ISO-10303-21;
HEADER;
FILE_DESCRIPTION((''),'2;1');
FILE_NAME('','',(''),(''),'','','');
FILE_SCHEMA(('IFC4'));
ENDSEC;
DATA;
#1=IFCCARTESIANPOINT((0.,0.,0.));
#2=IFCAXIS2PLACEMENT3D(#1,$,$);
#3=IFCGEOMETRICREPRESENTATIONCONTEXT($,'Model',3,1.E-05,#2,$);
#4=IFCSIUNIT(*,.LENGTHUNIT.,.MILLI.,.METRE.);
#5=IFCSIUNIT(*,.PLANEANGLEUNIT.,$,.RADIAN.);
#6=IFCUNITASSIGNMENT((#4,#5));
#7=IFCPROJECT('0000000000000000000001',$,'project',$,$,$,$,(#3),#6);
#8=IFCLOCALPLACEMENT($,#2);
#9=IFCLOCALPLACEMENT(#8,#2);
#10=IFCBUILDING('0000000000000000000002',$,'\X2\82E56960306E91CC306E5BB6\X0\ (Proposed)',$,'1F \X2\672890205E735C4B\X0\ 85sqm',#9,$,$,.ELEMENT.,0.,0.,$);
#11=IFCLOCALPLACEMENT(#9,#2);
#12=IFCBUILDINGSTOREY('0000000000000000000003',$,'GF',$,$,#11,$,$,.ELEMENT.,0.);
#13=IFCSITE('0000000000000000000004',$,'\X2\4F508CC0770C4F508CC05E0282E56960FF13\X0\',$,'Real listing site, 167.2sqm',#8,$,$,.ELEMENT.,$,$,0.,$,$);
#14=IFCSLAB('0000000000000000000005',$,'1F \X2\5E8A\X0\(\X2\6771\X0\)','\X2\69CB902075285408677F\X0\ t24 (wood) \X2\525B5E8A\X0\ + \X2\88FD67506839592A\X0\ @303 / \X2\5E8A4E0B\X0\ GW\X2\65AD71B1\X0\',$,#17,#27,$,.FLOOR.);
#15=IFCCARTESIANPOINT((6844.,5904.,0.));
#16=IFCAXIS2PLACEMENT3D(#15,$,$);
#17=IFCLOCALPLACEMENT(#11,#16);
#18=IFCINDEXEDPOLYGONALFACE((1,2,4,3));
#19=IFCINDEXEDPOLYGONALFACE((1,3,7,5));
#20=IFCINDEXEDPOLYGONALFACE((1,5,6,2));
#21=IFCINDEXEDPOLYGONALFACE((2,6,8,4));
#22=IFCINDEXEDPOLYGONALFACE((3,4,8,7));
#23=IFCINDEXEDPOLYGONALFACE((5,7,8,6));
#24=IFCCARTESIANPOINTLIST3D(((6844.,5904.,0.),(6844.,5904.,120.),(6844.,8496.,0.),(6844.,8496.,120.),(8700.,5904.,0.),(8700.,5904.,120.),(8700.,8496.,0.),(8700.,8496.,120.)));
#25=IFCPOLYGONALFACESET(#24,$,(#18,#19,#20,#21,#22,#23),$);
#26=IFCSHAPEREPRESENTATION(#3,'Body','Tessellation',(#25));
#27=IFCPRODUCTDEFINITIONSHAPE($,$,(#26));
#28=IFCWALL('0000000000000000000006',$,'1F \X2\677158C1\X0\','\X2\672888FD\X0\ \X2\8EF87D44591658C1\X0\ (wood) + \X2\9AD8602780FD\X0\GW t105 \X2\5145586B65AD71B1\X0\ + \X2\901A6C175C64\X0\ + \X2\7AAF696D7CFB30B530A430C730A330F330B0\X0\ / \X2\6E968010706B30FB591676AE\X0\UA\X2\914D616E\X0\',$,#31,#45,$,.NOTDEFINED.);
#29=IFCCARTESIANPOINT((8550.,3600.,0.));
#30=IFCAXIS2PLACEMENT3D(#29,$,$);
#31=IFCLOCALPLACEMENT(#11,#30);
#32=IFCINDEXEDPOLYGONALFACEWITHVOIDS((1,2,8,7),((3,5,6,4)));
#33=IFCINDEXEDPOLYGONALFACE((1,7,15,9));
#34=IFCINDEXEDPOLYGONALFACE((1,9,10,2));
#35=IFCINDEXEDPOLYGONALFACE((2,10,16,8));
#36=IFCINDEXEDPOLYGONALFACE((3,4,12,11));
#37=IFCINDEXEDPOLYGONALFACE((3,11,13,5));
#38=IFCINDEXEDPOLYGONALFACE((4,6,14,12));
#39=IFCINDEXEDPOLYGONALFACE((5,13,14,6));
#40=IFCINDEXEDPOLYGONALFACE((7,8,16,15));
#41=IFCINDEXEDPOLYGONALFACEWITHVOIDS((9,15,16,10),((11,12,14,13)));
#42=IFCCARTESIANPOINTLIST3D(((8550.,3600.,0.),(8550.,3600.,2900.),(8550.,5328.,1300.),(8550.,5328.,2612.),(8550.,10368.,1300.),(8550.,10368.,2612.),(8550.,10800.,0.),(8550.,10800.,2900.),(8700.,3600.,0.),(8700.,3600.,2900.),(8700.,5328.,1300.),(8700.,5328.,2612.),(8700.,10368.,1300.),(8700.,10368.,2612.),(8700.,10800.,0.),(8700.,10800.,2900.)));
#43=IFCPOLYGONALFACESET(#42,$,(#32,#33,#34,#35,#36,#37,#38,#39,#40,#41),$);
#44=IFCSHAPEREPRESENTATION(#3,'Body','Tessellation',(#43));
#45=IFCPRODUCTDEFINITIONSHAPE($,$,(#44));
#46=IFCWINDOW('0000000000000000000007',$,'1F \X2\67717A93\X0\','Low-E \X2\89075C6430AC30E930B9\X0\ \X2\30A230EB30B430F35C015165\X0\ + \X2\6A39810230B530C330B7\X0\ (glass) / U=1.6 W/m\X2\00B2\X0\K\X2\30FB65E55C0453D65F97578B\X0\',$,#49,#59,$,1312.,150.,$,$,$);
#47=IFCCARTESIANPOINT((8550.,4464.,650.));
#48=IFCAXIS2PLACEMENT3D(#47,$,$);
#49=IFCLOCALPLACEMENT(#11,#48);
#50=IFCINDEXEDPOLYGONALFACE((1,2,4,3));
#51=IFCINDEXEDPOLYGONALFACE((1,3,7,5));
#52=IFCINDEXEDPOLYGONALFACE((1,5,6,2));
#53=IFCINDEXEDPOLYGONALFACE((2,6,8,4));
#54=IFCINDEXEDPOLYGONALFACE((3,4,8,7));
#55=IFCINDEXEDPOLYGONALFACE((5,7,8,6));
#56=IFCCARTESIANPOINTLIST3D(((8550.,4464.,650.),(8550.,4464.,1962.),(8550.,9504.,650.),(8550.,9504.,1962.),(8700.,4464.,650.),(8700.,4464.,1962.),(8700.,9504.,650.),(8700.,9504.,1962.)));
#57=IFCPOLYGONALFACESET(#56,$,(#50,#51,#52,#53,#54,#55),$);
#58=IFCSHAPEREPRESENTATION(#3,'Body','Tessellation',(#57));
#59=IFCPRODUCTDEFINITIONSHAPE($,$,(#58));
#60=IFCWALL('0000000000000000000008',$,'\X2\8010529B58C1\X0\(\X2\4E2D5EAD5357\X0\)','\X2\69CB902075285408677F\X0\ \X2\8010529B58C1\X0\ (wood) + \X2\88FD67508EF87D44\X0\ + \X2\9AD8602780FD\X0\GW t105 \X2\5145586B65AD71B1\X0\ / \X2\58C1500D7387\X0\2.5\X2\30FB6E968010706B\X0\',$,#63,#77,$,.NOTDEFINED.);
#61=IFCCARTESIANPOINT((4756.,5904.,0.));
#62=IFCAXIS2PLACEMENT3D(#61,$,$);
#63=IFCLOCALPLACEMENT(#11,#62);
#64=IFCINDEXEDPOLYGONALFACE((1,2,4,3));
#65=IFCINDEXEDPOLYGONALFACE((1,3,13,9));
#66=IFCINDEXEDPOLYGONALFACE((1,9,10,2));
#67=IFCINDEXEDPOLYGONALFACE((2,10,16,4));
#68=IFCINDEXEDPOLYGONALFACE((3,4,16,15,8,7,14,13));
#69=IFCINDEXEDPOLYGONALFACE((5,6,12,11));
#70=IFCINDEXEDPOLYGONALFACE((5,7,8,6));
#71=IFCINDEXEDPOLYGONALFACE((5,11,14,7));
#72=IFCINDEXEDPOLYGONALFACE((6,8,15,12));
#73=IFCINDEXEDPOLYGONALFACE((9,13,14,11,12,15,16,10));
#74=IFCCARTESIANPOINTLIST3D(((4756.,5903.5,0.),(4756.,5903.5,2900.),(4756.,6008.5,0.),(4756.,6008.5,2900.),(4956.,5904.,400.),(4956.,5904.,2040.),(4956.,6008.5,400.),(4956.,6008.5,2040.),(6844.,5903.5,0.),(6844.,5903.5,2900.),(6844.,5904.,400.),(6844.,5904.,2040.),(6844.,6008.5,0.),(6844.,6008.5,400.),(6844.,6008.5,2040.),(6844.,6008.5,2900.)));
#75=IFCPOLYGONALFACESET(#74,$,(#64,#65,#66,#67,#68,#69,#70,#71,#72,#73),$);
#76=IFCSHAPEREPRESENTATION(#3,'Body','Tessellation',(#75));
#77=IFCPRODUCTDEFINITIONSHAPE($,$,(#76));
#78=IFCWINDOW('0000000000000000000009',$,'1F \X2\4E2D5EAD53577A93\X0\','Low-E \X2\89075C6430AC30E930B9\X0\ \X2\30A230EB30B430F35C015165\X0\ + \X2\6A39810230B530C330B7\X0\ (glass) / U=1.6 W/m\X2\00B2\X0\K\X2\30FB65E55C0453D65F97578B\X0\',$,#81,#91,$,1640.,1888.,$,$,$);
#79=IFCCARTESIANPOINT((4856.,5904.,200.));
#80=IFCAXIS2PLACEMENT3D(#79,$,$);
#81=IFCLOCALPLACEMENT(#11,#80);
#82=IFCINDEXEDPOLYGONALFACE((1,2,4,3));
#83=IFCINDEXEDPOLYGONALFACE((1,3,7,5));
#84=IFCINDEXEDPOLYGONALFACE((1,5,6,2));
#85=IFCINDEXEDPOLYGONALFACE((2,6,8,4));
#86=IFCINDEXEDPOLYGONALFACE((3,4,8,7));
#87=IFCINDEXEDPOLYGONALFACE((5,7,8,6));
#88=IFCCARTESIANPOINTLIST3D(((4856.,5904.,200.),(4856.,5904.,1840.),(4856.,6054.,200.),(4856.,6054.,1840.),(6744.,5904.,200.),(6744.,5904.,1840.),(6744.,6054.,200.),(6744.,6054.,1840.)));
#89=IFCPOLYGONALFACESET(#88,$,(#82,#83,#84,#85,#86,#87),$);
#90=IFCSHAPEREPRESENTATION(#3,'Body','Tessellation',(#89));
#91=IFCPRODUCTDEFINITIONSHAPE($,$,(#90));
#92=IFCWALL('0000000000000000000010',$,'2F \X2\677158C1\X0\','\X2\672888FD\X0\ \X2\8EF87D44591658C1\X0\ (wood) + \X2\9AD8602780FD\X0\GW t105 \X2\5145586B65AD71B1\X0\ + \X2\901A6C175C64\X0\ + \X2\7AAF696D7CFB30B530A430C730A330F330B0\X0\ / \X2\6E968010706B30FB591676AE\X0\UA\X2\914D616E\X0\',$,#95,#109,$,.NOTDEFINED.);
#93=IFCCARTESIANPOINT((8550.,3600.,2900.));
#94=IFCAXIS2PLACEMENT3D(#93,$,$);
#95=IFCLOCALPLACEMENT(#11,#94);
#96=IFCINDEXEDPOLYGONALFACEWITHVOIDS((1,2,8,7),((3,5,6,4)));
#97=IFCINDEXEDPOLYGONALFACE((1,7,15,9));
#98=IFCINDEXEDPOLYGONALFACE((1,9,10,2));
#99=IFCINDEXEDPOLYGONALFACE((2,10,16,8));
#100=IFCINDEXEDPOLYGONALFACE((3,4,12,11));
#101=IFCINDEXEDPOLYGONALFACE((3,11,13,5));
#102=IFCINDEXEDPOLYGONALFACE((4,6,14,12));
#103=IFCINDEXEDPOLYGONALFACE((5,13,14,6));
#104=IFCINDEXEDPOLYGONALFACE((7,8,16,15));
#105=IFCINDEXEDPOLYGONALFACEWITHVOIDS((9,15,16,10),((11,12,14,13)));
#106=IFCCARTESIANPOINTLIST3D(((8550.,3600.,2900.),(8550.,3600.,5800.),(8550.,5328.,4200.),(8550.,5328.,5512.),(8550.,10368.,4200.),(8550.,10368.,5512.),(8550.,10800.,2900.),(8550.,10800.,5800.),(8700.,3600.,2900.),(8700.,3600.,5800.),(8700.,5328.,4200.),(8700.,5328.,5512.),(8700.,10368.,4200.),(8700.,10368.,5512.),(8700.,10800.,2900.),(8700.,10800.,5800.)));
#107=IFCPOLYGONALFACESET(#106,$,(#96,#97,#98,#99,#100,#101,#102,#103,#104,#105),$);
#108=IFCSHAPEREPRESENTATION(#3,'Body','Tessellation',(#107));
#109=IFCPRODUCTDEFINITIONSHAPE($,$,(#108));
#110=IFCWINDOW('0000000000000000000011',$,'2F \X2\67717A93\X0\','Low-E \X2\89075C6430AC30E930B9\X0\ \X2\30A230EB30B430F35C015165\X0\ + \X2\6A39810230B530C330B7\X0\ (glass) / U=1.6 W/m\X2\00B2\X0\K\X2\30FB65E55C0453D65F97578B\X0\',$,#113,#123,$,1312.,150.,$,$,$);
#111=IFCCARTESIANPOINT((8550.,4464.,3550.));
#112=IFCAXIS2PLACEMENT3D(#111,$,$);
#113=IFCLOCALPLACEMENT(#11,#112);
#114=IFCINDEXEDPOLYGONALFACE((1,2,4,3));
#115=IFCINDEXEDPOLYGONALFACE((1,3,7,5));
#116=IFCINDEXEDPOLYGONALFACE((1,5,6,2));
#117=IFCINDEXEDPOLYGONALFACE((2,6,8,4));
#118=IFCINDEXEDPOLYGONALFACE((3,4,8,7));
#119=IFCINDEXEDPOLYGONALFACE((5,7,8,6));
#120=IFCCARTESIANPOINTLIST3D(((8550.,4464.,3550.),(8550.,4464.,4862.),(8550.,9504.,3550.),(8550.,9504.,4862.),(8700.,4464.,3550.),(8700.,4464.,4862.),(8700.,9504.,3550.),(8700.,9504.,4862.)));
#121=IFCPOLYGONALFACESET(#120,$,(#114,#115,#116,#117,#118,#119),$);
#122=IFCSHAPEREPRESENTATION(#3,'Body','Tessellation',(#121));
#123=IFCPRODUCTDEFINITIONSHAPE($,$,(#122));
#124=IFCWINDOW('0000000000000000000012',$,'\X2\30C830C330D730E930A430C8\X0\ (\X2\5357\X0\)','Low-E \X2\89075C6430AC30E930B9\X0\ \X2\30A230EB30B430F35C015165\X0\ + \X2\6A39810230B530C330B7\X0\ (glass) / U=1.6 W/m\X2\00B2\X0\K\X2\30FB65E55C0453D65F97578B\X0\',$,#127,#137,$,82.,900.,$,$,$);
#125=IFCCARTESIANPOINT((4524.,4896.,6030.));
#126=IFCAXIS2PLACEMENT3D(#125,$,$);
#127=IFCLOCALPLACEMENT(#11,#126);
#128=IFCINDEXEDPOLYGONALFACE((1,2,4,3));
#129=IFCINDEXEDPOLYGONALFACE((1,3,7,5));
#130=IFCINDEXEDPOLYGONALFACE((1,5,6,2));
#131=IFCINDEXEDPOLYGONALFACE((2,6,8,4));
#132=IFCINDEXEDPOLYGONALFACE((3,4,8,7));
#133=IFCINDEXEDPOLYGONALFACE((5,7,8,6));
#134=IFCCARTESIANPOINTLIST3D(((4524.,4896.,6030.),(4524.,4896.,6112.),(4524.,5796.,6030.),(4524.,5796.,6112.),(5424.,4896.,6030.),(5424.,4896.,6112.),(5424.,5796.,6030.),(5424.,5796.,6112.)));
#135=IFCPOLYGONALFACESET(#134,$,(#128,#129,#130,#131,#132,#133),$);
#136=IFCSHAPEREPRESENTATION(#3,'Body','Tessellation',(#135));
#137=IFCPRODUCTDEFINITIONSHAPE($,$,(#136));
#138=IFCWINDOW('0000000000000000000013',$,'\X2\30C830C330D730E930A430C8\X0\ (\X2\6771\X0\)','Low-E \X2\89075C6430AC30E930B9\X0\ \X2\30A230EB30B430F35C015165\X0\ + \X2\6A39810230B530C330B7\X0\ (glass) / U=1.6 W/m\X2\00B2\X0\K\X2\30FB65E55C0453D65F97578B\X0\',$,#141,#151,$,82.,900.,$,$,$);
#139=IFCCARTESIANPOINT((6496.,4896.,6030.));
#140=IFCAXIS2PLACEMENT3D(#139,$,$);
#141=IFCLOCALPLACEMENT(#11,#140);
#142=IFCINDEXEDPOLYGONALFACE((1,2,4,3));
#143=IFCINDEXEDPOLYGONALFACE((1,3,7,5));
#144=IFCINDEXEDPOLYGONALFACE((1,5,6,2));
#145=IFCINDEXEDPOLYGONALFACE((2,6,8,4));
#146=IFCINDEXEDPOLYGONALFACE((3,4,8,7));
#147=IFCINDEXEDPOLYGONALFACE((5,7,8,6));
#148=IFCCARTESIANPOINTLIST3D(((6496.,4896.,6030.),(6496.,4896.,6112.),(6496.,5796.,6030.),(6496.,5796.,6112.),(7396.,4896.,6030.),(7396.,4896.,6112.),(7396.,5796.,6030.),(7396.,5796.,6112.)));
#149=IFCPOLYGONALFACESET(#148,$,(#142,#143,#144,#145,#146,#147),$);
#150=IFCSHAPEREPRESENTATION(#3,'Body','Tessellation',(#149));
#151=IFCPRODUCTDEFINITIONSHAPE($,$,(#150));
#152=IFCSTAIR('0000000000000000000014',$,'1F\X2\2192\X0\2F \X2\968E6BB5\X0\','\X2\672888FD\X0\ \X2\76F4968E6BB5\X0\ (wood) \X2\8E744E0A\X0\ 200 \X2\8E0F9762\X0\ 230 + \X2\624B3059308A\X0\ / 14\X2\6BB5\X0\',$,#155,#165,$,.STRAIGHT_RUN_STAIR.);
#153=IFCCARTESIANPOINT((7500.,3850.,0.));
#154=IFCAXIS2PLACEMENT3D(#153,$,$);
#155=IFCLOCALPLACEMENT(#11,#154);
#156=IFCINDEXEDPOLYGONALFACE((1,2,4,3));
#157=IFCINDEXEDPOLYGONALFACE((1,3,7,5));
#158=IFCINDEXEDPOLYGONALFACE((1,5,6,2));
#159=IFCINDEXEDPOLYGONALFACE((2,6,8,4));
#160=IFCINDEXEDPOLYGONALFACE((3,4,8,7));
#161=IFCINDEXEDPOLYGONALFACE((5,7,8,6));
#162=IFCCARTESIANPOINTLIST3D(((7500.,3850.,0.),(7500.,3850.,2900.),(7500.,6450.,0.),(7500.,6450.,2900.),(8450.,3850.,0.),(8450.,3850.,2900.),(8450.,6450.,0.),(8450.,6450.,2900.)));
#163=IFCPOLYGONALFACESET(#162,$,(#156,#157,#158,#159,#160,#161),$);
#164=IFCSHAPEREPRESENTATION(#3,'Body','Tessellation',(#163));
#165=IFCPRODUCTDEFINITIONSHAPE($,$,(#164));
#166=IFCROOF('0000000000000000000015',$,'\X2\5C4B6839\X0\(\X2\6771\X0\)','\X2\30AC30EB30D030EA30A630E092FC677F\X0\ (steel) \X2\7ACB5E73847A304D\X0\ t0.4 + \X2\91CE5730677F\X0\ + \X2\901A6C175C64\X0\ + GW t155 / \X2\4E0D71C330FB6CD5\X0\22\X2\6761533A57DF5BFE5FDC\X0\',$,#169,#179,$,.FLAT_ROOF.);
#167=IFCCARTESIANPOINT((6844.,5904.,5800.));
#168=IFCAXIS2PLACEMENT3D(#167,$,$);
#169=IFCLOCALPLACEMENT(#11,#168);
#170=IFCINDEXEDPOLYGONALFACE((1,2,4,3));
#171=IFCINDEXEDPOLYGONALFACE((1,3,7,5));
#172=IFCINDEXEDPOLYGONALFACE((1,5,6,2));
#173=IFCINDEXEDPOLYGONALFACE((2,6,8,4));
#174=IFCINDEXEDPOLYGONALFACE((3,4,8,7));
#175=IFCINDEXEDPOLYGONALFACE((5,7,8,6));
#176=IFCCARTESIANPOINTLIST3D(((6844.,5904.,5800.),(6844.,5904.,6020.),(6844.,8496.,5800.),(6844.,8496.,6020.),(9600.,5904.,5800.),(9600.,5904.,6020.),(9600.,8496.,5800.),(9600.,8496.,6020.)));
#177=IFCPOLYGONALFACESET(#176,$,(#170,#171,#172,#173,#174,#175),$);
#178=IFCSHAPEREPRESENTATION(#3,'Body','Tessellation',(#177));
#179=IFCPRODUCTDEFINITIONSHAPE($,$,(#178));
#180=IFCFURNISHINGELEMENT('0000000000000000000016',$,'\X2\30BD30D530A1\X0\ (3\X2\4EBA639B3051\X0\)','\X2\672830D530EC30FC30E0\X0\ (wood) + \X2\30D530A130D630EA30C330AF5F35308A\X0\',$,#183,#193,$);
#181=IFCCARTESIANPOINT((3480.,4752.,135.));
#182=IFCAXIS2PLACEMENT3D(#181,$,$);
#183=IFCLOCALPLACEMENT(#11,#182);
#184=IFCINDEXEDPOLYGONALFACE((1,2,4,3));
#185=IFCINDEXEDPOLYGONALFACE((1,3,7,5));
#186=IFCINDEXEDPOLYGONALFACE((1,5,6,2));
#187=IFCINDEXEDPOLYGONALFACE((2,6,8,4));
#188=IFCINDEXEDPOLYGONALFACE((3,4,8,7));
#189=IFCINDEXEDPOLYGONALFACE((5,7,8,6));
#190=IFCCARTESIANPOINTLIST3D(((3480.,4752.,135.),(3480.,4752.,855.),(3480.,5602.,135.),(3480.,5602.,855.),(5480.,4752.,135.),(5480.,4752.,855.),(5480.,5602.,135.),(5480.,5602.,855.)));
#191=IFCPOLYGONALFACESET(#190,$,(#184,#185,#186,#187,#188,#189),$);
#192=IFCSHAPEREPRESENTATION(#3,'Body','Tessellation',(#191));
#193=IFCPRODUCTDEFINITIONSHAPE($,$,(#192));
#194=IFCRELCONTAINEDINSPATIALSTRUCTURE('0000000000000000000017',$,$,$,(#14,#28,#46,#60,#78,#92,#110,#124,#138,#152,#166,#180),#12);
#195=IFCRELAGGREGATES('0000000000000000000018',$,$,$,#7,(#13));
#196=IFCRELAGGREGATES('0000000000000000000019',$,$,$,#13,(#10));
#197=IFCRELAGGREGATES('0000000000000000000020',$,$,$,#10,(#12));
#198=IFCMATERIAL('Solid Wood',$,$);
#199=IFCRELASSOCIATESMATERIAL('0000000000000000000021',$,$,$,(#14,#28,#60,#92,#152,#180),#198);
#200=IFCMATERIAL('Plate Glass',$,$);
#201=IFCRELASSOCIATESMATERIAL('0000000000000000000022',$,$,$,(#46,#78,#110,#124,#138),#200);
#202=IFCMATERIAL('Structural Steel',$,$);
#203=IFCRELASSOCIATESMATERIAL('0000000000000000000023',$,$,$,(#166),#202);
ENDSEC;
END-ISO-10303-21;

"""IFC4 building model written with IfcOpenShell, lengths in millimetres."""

from ifc_helpers import new_model, si_unit, frame, frame_2d, origin, place, context, project, spatial, rectangle, extrude, material, element, fill, save


model = new_model("IFC4")

# Units and contexts
model_context = context("Model", 3, precision=1e-05, world=origin())
ifc_project = project(units=[si_unit("LENGTHUNIT", "METRE", prefix="MILLI"), si_unit("PLANEANGLEUNIT", "RADIAN")], contexts=[model_context])

# Site, building, storey
site_placement = place(None, origin())
site = spatial("IfcSite", under=ifc_project, at=site_placement, Name="佐賀県佐賀市若楠３", ObjectType="Real listing site, 167.2sqm", CompositionType="ELEMENT", RefElevation=0.0)
building_placement = place(site_placement, origin())
building = spatial("IfcBuilding", under=site, at=building_placement, Name="若楠の里の家 (Proposed)", ObjectType="1F 木造平屋 85sqm", CompositionType="ELEMENT", ElevationOfRefHeight=0.0, ElevationOfTerrain=0.0)
storey_placement = place(building_placement, origin())
storey = spatial("IfcBuildingStorey", under=building, at=storey_placement, Name="GF", CompositionType="ELEMENT", Elevation=0.0)

# Slab
ifc_material_1 = material(Name="Solid Wood")
slab_placement = place(storey_placement, frame((6844.0, 5904.0, 0.0)))
element("IfcSlab", 1, at=slab_placement, inside=storey, material=ifc_material_1, Name="1F 床(東)", Description="構造用合板 t24 (wood) 剛床 + 製材根太 @303 / 床下 GW断熱", PredefinedType="FLOOR", context=model_context, shape_type="SweptSolid", body=[
    extrude(rectangle(XDim=1856.0, YDim=2592.0, at=frame_2d((928.0, 1296.0))), frame((6844.0, 5904.0, 0.0)), (0.0, 0.0, 1.0), 120.0),
])

# Walls, openings, windows
wall_1_placement = place(storey_placement, frame((8550.0, 3600.0, 0.0)))
wall_1 = element("IfcWall", 2, at=wall_1_placement, inside=storey, material=ifc_material_1, Name="1F 東壁", Description="木製 軸組外壁 (wood) + 高性能GW t105 充填断熱 + 通気層 + 窯業系サイディング / 準耐火・外皮UA配慮", PredefinedType="NOTDEFINED", context=model_context, shape_type="SweptSolid", body=[
    extrude(rectangle(XDim=150.0, YDim=7200.0, at=frame_2d((75.0, 3600.0))), frame((8550.0, 3600.0, 0.0)), (0.0, 0.0, 1.0), 2900.0),
])
opening_1_placement = place(storey_placement, frame((8550.0, 4464.0, 650.0)))
opening_1 = element("IfcOpeningElement", 3, at=opening_1_placement, cuts=wall_1, PredefinedType="NOTDEFINED", context=model_context, shape_type="SweptSolid", body=[
    extrude(rectangle(XDim=150.0, YDim=5040.0, at=frame_2d((75.0, 2520.0))), frame((8550.0, 4464.0, 650.0)), (0.0, 0.0, 1.0), 1312.0),
])
ifc_material_2 = material(Name="Plate Glass")
window_1_placement = place(storey_placement, frame((8550.0, 4464.0, 650.0)))
window_1 = element("IfcWindow", 4, at=window_1_placement, inside=storey, material=ifc_material_2, Name="1F 東窓", Description="Low-E 複層ガラス アルゴン封入 + 樹脂サッシ (glass) / U=1.6 W/m²K・日射取得型", OverallHeight=1312.0, OverallWidth=150.0, context=model_context, shape_type="SweptSolid", body=[
    extrude(rectangle(XDim=150.0, YDim=5040.0, at=frame_2d((75.0, 2520.0))), frame((8550.0, 4464.0, 650.0)), (0.0, 0.0, 1.0), 1312.0),
])
fill(opening_1, window_1)
wall_2_placement = place(storey_placement, frame((4756.0, 5904.0, 0.0)))
wall_2 = element("IfcWall", 5, at=wall_2_placement, inside=storey, material=ifc_material_1, Name="耐力壁(中庭南)", Description="構造用合板 耐力壁 (wood) + 製材軸組 + 高性能GW t105 充填断熱 / 壁倍率2.5・準耐火", PredefinedType="NOTDEFINED", context=model_context, shape_type="SweptSolid", body=[
    extrude(rectangle(XDim=2088.0, YDim=105.0, at=frame_2d((1044.0, 52.0))), frame((4756.0, 5904.0, 0.0)), (0.0, 0.0, 1.0), 2900.0),
])
opening_2_placement = place(storey_placement, frame((4856.0, 5904.0, 200.0)))
opening_2 = element("IfcOpeningElement", 6, at=opening_2_placement, cuts=wall_2, PredefinedType="NOTDEFINED", context=model_context, shape_type="SweptSolid", body=[
    extrude(rectangle(XDim=1888.0, YDim=150.0, at=frame_2d((944.0, 75.0))), frame((4856.0, 5904.0, 200.0)), (0.0, 0.0, 1.0), 1640.0),
])
window_2_placement = place(storey_placement, frame((4856.0, 5904.0, 200.0)))
window_2 = element("IfcWindow", 7, at=window_2_placement, inside=storey, material=ifc_material_2, Name="1F 中庭南窓", Description="Low-E 複層ガラス アルゴン封入 + 樹脂サッシ (glass) / U=1.6 W/m²K・日射取得型", OverallHeight=1640.0, OverallWidth=1888.0, context=model_context, shape_type="SweptSolid", body=[
    extrude(rectangle(XDim=1888.0, YDim=150.0, at=frame_2d((944.0, 75.0))), frame((4856.0, 5904.0, 200.0)), (0.0, 0.0, 1.0), 1640.0),
])
fill(opening_2, window_2)

# Wall, opening, window
wall_3_placement = place(storey_placement, frame((8550.0, 3600.0, 2900.0)))
wall_3 = element("IfcWall", 8, at=wall_3_placement, inside=storey, material=ifc_material_1, Name="2F 東壁", Description="木製 軸組外壁 (wood) + 高性能GW t105 充填断熱 + 通気層 + 窯業系サイディング / 準耐火・外皮UA配慮", PredefinedType="NOTDEFINED", context=model_context, shape_type="SweptSolid", body=[
    extrude(rectangle(XDim=150.0, YDim=7200.0, at=frame_2d((75.0, 3600.0))), frame((8550.0, 3600.0, 2900.0)), (0.0, 0.0, 1.0), 2900.0),
])
opening_3_placement = place(storey_placement, frame((8550.0, 4464.0, 3550.0)))
opening_3 = element("IfcOpeningElement", 9, at=opening_3_placement, cuts=wall_3, PredefinedType="NOTDEFINED", context=model_context, shape_type="SweptSolid", body=[
    extrude(rectangle(XDim=150.0, YDim=5040.0, at=frame_2d((75.0, 2520.0))), frame((8550.0, 4464.0, 3550.0)), (0.0, 0.0, 1.0), 1312.0),
])
window_3_placement = place(storey_placement, frame((8550.0, 4464.0, 3550.0)))
window_3 = element("IfcWindow", 10, at=window_3_placement, inside=storey, material=ifc_material_2, Name="2F 東窓", Description="Low-E 複層ガラス アルゴン封入 + 樹脂サッシ (glass) / U=1.6 W/m²K・日射取得型", OverallHeight=1312.0, OverallWidth=150.0, context=model_context, shape_type="SweptSolid", body=[
    extrude(rectangle(XDim=150.0, YDim=5040.0, at=frame_2d((75.0, 2520.0))), frame((8550.0, 4464.0, 3550.0)), (0.0, 0.0, 1.0), 1312.0),
])
fill(opening_3, window_3)

# Windows
window_4_placement = place(storey_placement, frame((4524.0, 4896.0, 6030.0)))
element("IfcWindow", 11, at=window_4_placement, inside=storey, material=ifc_material_2, Name="トップライト (南)", Description="Low-E 複層ガラス アルゴン封入 + 樹脂サッシ (glass) / U=1.6 W/m²K・日射取得型", OverallHeight=82.0, OverallWidth=900.0, context=model_context, shape_type="SweptSolid", body=[
    extrude(rectangle(XDim=900.0, YDim=900.0, at=frame_2d((450.0, 450.0))), frame((4524.0, 4896.0, 6030.0)), (0.0, 0.0, 1.0), 82.0),
])
window_5_placement = place(storey_placement, frame((6496.0, 4896.0, 6030.0)))
element("IfcWindow", 12, at=window_5_placement, inside=storey, material=ifc_material_2, Name="トップライト (東)", Description="Low-E 複層ガラス アルゴン封入 + 樹脂サッシ (glass) / U=1.6 W/m²K・日射取得型", OverallHeight=82.0, OverallWidth=900.0, context=model_context, shape_type="SweptSolid", body=[
    extrude(rectangle(XDim=900.0, YDim=900.0, at=frame_2d((450.0, 450.0))), frame((6496.0, 4896.0, 6030.0)), (0.0, 0.0, 1.0), 82.0),
])

# Stair
stair_placement = place(storey_placement, frame((7500.0, 3850.0, 0.0)))
element("IfcStair", 13, at=stair_placement, inside=storey, material=ifc_material_1, Name="1F→2F 階段", Description="木製 直階段 (wood) 蹴上 200 踏面 230 + 手すり / 14段", PredefinedType="STRAIGHT_RUN_STAIR", context=model_context, shape_type="SweptSolid", body=[
    extrude(rectangle(XDim=950.0, YDim=2600.0, at=frame_2d((475.0, 1300.0))), frame((7500.0, 3850.0, 0.0)), (0.0, 0.0, 1.0), 2900.0),
])

# Roof
ifc_material_3 = material(Name="Structural Steel")
roof_placement = place(storey_placement, frame((6844.0, 5904.0, 5800.0)))
element("IfcRoof", 14, at=roof_placement, inside=storey, material=ifc_material_3, Name="屋根(東)", Description="ガルバリウム鋼板 (steel) 立平葺き t0.4 + 野地板 + 通気層 + GW t155 / 不燃・法22条区域対応", PredefinedType="FLAT_ROOF", context=model_context, shape_type="SweptSolid", body=[
    extrude(rectangle(XDim=2756.0, YDim=2592.0, at=frame_2d((1378.0, 1296.0))), frame((6844.0, 5904.0, 5800.0)), (0.0, 0.0, 1.0), 220.0),
])

# Furnishing element
furnishing_1_placement = place(storey_placement, frame((3480.0, 4752.0, 135.0)))
element("IfcFurnishingElement", 15, at=furnishing_1_placement, inside=storey, material=ifc_material_1, Name="ソファ (3人掛け)", Description="木フレーム (wood) + ファブリック張り", context=model_context, shape_type="SweptSolid", body=[
    extrude(rectangle(XDim=2000.0, YDim=850.0, at=frame_2d((1000.0, 425.0))), frame((3480.0, 4752.0, 135.0)), (0.0, 0.0, 1.0), 720.0),
])

save(model, "model.ifc")
